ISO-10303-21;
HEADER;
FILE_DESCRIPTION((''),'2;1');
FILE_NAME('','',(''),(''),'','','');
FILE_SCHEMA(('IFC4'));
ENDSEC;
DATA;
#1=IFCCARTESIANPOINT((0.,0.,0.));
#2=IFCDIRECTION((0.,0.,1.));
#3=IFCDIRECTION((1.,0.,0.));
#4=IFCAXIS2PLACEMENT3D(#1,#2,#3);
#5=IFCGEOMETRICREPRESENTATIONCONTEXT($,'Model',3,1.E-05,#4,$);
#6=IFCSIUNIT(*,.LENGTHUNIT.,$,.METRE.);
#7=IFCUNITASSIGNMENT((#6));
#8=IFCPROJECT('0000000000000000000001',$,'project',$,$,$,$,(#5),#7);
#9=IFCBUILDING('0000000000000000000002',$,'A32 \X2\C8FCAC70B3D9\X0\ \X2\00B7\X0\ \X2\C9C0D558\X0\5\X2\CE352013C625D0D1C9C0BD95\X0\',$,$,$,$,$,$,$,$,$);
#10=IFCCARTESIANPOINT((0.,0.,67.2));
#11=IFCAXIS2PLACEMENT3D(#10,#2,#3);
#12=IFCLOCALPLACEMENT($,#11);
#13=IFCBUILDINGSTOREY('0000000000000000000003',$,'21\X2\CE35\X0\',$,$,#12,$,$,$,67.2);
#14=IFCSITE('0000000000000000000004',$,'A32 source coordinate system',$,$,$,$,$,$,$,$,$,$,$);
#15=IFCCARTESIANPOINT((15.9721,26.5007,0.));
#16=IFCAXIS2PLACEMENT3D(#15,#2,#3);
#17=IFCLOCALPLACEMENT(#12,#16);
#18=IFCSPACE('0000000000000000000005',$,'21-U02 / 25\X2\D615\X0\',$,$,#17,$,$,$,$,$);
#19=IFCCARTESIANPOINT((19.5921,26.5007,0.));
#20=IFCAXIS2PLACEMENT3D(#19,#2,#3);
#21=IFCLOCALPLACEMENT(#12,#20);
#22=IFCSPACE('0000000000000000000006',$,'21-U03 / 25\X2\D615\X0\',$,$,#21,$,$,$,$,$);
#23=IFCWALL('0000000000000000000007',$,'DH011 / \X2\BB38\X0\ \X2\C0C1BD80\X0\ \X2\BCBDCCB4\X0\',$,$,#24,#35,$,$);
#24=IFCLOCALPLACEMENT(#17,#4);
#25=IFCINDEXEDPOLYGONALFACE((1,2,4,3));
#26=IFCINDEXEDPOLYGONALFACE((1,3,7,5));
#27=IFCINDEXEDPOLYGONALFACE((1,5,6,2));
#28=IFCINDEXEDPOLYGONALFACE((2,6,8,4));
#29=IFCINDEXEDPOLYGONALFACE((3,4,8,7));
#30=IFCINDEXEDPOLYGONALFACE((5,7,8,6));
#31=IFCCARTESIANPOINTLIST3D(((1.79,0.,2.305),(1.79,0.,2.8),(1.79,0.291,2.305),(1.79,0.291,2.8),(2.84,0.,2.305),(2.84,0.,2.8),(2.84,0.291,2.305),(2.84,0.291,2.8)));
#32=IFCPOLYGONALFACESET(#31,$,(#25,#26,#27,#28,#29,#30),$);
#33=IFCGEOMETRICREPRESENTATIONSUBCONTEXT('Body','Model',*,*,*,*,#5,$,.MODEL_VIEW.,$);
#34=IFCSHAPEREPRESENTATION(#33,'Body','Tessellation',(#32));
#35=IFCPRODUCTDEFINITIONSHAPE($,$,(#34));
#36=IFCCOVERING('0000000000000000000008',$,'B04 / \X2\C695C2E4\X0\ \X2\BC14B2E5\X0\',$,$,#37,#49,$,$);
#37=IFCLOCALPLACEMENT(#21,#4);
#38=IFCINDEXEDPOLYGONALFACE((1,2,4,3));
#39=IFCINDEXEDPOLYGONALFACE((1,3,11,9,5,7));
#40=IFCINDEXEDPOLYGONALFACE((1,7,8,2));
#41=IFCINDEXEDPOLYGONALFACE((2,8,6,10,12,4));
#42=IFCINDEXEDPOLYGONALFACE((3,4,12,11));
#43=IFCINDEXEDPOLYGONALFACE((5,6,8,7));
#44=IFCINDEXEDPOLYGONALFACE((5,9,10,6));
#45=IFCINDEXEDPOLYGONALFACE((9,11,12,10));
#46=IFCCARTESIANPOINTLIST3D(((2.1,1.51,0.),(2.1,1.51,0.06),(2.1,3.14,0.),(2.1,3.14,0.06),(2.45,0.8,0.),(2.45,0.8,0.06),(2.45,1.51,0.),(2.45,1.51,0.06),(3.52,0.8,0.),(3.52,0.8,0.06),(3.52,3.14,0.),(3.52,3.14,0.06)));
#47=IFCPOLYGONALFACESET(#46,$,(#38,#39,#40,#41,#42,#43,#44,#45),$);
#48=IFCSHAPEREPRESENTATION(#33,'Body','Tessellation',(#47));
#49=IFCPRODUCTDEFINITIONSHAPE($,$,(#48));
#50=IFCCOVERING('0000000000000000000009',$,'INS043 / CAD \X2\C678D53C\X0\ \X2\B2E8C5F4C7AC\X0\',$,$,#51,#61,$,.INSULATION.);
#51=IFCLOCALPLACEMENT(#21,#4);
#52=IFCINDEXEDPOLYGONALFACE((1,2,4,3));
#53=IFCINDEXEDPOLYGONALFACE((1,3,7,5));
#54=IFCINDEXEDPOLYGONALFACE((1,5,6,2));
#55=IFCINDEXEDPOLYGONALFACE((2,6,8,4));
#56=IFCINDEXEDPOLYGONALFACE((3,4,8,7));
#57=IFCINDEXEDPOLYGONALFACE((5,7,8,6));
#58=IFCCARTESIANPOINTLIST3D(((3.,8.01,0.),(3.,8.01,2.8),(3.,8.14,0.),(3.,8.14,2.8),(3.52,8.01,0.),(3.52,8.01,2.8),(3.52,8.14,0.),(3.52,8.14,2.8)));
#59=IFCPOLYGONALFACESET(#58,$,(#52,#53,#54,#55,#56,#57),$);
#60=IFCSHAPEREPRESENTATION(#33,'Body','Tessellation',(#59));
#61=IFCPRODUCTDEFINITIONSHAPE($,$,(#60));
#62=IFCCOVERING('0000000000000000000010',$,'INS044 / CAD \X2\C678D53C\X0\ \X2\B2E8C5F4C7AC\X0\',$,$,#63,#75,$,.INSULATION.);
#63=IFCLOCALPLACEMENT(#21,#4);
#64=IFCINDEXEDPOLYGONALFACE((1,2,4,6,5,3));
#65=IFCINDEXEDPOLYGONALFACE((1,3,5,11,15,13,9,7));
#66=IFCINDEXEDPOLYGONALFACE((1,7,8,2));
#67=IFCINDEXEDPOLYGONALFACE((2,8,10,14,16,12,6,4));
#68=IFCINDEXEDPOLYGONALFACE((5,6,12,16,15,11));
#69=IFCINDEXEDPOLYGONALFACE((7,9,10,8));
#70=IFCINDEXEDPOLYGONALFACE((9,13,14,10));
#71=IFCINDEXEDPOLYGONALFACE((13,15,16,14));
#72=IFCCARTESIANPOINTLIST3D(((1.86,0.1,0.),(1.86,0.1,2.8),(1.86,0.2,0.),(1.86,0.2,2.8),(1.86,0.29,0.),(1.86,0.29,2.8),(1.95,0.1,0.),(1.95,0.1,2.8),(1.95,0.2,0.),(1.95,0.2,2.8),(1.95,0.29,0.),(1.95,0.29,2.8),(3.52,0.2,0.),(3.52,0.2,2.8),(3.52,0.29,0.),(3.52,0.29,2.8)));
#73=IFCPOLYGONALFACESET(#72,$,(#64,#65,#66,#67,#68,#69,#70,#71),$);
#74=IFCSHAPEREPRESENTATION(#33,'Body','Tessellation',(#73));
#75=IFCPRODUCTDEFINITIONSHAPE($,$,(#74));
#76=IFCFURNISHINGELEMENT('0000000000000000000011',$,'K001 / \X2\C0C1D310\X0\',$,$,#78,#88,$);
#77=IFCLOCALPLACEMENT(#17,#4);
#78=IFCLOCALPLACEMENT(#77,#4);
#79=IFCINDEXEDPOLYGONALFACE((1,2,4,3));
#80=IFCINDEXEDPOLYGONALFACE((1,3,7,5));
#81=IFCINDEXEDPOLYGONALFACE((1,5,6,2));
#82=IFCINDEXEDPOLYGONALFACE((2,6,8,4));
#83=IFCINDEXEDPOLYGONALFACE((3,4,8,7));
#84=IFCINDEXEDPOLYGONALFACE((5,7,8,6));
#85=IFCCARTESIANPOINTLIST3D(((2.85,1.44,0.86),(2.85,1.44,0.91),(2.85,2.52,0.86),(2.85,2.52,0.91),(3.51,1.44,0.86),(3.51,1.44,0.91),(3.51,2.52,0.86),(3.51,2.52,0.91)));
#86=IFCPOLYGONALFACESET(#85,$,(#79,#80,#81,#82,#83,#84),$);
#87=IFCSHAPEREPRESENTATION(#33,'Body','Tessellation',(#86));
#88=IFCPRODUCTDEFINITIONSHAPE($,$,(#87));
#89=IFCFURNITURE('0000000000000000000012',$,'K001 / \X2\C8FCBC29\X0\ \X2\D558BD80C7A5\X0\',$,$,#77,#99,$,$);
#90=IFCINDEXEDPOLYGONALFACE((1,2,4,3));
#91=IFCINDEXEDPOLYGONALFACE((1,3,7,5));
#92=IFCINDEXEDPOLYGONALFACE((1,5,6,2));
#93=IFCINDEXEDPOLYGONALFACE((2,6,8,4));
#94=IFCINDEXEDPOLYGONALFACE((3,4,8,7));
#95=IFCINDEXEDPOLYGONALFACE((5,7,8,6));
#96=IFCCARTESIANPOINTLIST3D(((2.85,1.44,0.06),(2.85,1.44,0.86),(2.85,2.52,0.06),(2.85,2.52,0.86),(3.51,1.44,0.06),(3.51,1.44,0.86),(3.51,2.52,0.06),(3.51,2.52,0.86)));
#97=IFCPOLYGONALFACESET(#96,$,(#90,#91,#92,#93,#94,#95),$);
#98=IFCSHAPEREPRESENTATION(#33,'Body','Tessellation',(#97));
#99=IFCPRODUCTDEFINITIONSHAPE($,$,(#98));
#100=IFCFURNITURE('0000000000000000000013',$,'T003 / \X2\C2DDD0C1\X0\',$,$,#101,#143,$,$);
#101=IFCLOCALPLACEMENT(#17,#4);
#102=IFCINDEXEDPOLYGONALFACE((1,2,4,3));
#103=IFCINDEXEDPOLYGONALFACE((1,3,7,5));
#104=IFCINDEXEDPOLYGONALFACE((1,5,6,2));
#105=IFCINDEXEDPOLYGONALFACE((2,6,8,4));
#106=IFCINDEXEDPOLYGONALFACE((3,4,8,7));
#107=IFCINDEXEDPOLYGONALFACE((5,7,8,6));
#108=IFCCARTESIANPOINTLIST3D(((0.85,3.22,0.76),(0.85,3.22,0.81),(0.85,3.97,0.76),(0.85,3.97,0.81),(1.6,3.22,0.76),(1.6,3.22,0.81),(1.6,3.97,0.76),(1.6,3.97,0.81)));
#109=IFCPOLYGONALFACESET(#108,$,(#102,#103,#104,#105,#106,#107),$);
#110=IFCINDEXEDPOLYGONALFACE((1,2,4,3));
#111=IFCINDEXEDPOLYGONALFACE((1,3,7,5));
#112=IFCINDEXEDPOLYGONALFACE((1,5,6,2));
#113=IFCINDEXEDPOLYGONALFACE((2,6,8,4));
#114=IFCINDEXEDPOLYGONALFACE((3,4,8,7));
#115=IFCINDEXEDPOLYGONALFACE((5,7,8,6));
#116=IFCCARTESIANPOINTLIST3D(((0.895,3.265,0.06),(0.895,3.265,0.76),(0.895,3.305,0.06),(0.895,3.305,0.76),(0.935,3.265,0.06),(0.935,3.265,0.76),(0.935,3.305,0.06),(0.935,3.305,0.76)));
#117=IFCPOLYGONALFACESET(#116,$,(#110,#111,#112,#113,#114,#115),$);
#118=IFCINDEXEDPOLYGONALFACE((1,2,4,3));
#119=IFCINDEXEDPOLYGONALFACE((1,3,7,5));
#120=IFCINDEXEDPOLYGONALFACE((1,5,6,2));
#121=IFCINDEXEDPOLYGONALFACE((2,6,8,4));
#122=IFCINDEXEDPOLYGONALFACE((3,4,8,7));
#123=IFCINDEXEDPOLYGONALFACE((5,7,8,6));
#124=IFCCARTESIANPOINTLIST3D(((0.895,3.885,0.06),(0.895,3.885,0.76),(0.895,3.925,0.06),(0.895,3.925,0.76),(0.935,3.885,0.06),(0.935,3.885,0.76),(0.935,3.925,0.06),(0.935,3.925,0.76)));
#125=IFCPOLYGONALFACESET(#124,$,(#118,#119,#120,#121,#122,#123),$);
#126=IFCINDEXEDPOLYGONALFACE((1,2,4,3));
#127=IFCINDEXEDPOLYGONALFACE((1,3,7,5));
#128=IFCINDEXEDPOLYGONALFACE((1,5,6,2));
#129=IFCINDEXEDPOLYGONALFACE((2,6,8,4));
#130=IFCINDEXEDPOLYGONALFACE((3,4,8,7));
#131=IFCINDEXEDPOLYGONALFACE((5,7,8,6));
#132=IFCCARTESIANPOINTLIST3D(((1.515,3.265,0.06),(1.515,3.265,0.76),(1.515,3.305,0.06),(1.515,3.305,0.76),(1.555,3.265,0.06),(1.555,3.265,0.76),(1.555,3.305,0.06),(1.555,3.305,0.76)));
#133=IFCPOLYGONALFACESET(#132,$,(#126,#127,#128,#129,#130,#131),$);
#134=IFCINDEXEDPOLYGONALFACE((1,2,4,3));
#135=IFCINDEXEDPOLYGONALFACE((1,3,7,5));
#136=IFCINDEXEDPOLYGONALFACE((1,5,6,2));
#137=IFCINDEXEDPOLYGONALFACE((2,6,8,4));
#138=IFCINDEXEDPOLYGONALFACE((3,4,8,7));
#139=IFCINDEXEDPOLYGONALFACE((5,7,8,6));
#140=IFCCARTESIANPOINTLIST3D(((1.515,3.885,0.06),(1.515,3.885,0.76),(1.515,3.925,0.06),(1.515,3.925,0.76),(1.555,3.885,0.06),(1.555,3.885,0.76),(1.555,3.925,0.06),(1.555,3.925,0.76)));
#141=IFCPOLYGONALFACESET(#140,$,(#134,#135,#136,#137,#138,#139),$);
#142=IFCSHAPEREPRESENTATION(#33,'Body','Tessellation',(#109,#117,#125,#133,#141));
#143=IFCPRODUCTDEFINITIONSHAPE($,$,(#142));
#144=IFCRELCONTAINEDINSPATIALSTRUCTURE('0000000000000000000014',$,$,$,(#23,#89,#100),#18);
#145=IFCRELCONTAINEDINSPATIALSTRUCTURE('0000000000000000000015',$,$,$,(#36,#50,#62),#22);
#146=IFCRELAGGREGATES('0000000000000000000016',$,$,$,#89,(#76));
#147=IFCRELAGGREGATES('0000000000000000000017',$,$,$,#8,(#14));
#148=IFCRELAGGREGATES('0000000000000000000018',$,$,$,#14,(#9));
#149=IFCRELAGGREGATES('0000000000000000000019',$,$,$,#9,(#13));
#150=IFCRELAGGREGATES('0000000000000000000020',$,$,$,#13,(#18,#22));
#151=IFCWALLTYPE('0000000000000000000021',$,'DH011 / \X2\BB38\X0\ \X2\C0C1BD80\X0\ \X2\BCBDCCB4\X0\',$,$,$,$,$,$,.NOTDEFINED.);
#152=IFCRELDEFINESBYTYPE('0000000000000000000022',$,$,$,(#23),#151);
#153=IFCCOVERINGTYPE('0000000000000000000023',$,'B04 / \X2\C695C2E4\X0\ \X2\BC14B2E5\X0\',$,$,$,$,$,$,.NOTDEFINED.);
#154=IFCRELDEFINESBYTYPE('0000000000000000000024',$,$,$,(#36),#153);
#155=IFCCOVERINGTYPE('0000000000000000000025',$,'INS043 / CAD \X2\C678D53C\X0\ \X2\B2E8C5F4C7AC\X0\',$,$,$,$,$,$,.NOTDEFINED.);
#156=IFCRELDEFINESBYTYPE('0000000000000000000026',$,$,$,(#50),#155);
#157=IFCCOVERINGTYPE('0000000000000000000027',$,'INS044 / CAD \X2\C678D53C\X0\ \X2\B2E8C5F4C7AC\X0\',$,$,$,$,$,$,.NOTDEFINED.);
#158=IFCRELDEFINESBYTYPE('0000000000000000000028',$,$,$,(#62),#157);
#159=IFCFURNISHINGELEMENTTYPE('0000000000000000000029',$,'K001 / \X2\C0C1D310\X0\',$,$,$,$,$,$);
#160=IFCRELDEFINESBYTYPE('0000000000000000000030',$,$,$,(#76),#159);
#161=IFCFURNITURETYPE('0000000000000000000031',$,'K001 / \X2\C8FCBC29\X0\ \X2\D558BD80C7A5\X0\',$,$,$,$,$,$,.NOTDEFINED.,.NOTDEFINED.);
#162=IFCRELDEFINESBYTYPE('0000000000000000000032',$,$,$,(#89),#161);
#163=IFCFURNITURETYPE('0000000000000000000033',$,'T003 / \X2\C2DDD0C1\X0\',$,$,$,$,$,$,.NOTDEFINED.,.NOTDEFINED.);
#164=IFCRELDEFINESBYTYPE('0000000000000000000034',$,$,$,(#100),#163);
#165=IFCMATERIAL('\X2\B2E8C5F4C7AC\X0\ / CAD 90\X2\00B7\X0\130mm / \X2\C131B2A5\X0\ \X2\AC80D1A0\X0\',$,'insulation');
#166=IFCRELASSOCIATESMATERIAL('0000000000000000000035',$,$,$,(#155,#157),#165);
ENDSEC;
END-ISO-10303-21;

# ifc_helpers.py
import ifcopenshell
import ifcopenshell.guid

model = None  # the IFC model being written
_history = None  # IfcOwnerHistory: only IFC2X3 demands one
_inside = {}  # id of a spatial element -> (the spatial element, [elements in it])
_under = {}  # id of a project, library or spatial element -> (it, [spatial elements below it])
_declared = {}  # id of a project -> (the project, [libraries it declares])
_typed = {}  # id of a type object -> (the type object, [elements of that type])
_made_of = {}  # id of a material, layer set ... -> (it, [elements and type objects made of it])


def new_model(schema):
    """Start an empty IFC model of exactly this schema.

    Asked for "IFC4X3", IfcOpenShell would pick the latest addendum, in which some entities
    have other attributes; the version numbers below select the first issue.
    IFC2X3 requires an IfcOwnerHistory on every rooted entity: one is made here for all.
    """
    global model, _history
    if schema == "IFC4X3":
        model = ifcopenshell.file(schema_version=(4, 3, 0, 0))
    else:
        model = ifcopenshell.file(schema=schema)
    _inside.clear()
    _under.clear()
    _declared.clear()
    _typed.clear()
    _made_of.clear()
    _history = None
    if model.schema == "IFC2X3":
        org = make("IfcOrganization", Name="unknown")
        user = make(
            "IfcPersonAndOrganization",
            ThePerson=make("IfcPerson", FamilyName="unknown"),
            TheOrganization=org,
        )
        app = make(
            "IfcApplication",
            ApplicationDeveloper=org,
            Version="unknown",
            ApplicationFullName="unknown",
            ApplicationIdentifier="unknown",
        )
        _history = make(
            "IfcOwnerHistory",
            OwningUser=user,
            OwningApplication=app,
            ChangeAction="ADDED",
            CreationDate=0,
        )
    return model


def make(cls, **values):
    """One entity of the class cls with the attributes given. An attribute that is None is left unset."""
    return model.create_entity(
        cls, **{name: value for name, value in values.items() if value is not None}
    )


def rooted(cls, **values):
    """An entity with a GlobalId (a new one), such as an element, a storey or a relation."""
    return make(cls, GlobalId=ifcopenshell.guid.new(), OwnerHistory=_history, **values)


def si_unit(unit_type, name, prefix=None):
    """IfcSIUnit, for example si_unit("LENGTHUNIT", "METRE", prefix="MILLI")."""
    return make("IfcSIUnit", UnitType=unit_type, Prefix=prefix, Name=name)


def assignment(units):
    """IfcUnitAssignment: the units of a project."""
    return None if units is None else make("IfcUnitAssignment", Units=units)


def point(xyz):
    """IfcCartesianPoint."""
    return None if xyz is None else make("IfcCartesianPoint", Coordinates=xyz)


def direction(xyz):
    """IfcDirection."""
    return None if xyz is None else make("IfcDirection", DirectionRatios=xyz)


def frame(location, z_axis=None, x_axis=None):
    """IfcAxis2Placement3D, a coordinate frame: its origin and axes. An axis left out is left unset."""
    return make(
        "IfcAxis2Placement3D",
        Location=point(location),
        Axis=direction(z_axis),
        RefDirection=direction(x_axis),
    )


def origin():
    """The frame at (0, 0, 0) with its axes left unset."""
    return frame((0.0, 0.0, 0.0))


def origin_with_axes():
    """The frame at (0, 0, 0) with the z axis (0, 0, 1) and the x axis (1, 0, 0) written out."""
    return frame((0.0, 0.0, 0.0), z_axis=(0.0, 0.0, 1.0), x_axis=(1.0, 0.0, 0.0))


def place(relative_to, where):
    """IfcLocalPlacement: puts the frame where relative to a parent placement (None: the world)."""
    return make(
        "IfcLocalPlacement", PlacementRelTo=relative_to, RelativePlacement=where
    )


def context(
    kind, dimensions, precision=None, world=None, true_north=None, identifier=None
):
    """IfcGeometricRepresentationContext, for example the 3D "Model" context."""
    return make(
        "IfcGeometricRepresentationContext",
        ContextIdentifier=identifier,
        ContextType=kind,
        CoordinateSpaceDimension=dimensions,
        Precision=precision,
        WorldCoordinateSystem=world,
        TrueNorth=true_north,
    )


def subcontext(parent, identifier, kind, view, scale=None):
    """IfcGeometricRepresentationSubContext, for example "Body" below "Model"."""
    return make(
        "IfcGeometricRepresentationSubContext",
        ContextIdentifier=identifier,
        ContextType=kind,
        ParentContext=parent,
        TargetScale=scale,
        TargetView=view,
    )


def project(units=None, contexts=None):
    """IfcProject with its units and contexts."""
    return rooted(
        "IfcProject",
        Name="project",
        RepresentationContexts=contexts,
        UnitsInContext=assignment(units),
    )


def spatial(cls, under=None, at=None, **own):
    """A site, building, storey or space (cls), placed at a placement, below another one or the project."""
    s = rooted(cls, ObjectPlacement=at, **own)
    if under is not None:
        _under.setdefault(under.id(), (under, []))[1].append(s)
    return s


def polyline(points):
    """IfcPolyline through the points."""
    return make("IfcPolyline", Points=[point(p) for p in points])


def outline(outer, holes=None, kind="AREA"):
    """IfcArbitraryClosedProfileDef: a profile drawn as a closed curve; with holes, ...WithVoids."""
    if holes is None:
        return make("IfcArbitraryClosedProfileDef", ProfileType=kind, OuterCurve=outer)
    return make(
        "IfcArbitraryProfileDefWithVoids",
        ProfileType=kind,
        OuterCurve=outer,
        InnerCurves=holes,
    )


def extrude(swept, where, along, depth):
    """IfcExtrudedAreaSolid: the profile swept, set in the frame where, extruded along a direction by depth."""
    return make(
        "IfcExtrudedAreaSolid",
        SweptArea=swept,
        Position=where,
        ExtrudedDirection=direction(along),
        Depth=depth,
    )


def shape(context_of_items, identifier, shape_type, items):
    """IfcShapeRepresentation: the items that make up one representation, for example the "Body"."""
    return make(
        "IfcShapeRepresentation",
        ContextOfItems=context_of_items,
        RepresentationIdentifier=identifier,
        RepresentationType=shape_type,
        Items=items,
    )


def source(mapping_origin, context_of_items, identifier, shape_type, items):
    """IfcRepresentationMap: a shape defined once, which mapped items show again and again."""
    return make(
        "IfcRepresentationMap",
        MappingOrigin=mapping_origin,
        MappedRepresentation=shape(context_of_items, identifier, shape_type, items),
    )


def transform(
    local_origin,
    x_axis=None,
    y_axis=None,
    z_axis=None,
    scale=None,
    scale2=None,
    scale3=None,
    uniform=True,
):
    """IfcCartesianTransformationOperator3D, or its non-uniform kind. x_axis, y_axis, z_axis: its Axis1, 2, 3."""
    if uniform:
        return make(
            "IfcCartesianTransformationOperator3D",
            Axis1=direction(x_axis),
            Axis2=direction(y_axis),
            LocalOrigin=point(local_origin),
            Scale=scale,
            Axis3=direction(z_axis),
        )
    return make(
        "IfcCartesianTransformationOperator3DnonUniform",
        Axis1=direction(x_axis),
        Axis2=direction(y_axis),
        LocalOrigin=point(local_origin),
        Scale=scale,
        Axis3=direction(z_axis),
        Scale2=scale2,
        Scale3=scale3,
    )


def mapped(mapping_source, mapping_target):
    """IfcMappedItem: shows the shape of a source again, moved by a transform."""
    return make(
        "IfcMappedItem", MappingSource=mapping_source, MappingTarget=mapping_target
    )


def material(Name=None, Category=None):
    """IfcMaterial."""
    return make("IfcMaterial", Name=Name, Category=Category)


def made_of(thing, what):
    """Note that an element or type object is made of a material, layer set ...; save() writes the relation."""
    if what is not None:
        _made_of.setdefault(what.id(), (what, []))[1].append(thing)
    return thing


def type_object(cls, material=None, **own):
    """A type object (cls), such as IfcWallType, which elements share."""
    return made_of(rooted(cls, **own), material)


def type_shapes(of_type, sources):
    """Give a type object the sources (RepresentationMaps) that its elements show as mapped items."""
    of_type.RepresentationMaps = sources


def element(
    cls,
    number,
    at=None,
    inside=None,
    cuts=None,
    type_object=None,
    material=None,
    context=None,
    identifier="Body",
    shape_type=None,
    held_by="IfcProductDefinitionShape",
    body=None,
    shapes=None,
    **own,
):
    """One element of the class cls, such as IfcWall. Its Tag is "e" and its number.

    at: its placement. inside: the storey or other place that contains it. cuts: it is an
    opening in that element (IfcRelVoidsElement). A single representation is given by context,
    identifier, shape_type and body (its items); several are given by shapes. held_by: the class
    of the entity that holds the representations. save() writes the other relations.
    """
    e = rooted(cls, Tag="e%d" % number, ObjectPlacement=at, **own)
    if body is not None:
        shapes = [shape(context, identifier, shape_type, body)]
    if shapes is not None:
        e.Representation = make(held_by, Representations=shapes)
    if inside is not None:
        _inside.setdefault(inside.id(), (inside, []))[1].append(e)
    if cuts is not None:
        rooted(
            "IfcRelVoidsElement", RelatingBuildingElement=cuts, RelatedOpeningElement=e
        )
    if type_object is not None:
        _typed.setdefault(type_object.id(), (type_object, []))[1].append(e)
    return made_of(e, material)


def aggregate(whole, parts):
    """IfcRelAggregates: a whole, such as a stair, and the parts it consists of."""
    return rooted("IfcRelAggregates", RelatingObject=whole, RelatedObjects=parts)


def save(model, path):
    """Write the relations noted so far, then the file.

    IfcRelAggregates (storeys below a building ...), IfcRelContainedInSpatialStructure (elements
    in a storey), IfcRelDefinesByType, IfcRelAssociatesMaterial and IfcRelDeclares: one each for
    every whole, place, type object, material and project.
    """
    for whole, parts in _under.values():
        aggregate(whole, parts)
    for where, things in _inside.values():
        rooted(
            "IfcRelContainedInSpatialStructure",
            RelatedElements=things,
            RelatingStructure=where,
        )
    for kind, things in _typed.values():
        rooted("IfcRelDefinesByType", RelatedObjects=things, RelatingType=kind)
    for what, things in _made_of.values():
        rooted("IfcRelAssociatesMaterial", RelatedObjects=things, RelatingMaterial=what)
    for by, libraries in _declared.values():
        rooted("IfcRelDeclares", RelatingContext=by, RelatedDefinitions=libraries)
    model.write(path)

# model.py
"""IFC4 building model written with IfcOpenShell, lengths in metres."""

from ifc_helpers import new_model, si_unit, frame, origin, origin_with_axes, place, context, subcontext, project, spatial, polyline, outline, extrude, source, transform, mapped, material, type_object, type_shapes, element, aggregate, save


model = new_model("IFC4")

# Units and contexts
model_context = context("Model", 3, precision=1e-05, world=origin_with_axes())
body_context = subcontext(model_context, "Body", "Model", "MODEL_VIEW")
ifc_project = project(units=[si_unit("LENGTHUNIT", "METRE")], contexts=[model_context])

# Site, building, storey, space
site = spatial("IfcSite", under=ifc_project, Name="A32 source coordinate system")
building = spatial("IfcBuilding", under=site, Name="A32 주거동 · 지하5층–옥탑지붕")
storey_placement = place(None, frame((0.0, 0.0, 67.2), z_axis=(0.0, 0.0, 1.0), x_axis=(1.0, 0.0, 0.0)))
storey = spatial("IfcBuildingStorey", under=building, at=storey_placement, Name="21층", Elevation=67.2)
space_1_placement = place(storey_placement, frame((15.9721, 26.5007, 0.0), z_axis=(0.0, 0.0, 1.0), x_axis=(1.0, 0.0, 0.0)))
space_1 = spatial("IfcSpace", under=storey, at=space_1_placement, Name="21-U02 / 25형")

# Wall
wall_type_1 = type_object("IfcWallType", Name="DH011 / 문 상부 벽체", PredefinedType="NOTDEFINED")
shared_shape_1 = source(origin(), body_context, "Body", "SweptSolid", [
    extrude(outline(polyline([(2.84, 0.0), (1.79, 0.0), (1.79, 0.291), (2.84, 0.291), (2.84, 0.0)])), frame((0.0, 0.0, 2.305)), (0.0, 0.0, 1.0), 0.495),
])
type_shapes(wall_type_1, [shared_shape_1])
wall_1_placement = place(space_1_placement, origin_with_axes())
element("IfcWall", 1, at=wall_1_placement, inside=space_1, type_object=wall_type_1, Name="DH011 / 문 상부 벽체", context=body_context, shape_type="MappedRepresentation", body=[
    mapped(shared_shape_1, transform((0.0, 0.0, 0.0), scale=1.0)),
])

# Shared definitions
space_2_placement = place(storey_placement, frame((19.5921, 26.5007, 0.0), z_axis=(0.0, 0.0, 1.0), x_axis=(1.0, 0.0, 0.0)))
space_2 = spatial("IfcSpace", under=storey, at=space_2_placement, Name="21-U03 / 25형")

# Coverings
covering_type_1 = type_object("IfcCoveringType", Name="B04 / 욕실 바닥", PredefinedType="NOTDEFINED")
shared_shape_2 = source(origin(), body_context, "Body", "SweptSolid", [
    extrude(outline(polyline([(2.1, 1.51), (2.1, 3.14), (3.52, 3.14), (3.52, 0.8), (2.45, 0.8), (2.45, 1.51), (2.1, 1.51)])), origin(), (0.0, 0.0, 1.0), 0.06),
])
type_shapes(covering_type_1, [shared_shape_2])
covering_1_placement = place(space_2_placement, origin_with_axes())
element("IfcCovering", 2, at=covering_1_placement, inside=space_2, type_object=covering_type_1, Name="B04 / 욕실 바닥", context=body_context, shape_type="MappedRepresentation", body=[
    mapped(shared_shape_2, transform((0.0, 0.0, 0.0), scale=1.0)),
])
ifc_material = material(Name="단열재 / CAD 90·130mm / 성능 검토", Category="insulation")
covering_type_2 = type_object("IfcCoveringType", Name="INS043 / CAD 외피 단열재", PredefinedType="NOTDEFINED", material=ifc_material)
shared_shape_3 = source(origin(), body_context, "Body", "SweptSolid", [
    extrude(outline(polyline([(3.52, 8.14), (3.52, 8.01), (3.0, 8.01), (3.0, 8.14), (3.52, 8.14)])), origin(), (0.0, 0.0, 1.0), 2.8),
])
type_shapes(covering_type_2, [shared_shape_3])
covering_2_placement = place(space_2_placement, origin_with_axes())
element("IfcCovering", 3, at=covering_2_placement, inside=space_2, type_object=covering_type_2, Name="INS043 / CAD 외피 단열재", PredefinedType="INSULATION", context=body_context, shape_type="MappedRepresentation", body=[
    mapped(shared_shape_3, transform((0.0, 0.0, 0.0), scale=1.0)),
])
covering_type_3 = type_object("IfcCoveringType", Name="INS044 / CAD 외피 단열재", PredefinedType="NOTDEFINED", material=ifc_material)
shared_shape_4 = source(origin(), body_context, "Body", "SweptSolid", [
    extrude(outline(polyline([(1.86, 0.2), (1.86, 0.29), (1.95, 0.29), (3.52, 0.29), (3.52, 0.2), (1.95, 0.2), (1.95, 0.1), (1.86, 0.1), (1.86, 0.2)])), origin(), (0.0, 0.0, 1.0), 2.8),
])
type_shapes(covering_type_3, [shared_shape_4])
covering_3_placement = place(space_2_placement, origin_with_axes())
element("IfcCovering", 4, at=covering_3_placement, inside=space_2, type_object=covering_type_3, Name="INS044 / CAD 외피 단열재", PredefinedType="INSULATION", context=body_context, shape_type="MappedRepresentation", body=[
    mapped(shared_shape_4, transform((0.0, 0.0, 0.0), scale=1.0)),
])

# Furnishing element
furnishing_element_type_1 = type_object("IfcFurnishingElementType", Name="K001 / 상판")
shared_shape_5 = source(origin(), body_context, "Body", "SweptSolid", [
    extrude(outline(polyline([(2.85, 2.52), (3.51, 2.52), (3.51, 1.44), (2.85, 1.44), (2.85, 2.52)])), frame((0.0, 0.0, 0.86)), (0.0, 0.0, 1.0), 0.05),
])
type_shapes(furnishing_element_type_1, [shared_shape_5])
furniture_1_placement = place(space_1_placement, origin_with_axes())
furnishing_1_placement = place(furniture_1_placement, origin_with_axes())
furnishing_1 = element("IfcFurnishingElement", 5, at=furnishing_1_placement, type_object=furnishing_element_type_1, Name="K001 / 상판", context=body_context, shape_type="MappedRepresentation", body=[
    mapped(shared_shape_5, transform((0.0, 0.0, 0.0), scale=1.0)),
])

# Furniture
furniture_type_1 = type_object("IfcFurnitureType", Name="K001 / 주방 하부장", AssemblyPlace="NOTDEFINED", PredefinedType="NOTDEFINED")
shared_shape_6 = source(origin(), body_context, "Body", "SweptSolid", [
    extrude(outline(polyline([(2.85, 1.44), (2.85, 2.52), (3.51, 2.52), (3.51, 1.44), (2.85, 1.44)])), frame((0.0, 0.0, 0.06)), (0.0, 0.0, 1.0), 0.8),
])
type_shapes(furniture_type_1, [shared_shape_6])
furniture_1 = element("IfcFurniture", 6, at=furniture_1_placement, inside=space_1, type_object=furniture_type_1, Name="K001 / 주방 하부장", context=body_context, shape_type="MappedRepresentation", body=[
    mapped(shared_shape_6, transform((0.0, 0.0, 0.0), scale=1.0)),
])
aggregate(furniture_1, [furnishing_1])
furniture_type_2 = type_object("IfcFurnitureType", Name="T003 / 식탁", AssemblyPlace="NOTDEFINED", PredefinedType="NOTDEFINED")
shared_shape_7 = source(origin(), body_context, "Body", "SweptSolid", [
    extrude(outline(polyline([(1.6, 3.97), (1.6, 3.22), (0.85, 3.22), (0.85, 3.97), (1.6, 3.97)])), frame((0.0, 0.0, 0.76)), (0.0, 0.0, 1.0), 0.05),
    extrude(outline(polyline([(0.895, 3.265), (0.895, 3.305), (0.935, 3.305), (0.935, 3.265), (0.895, 3.265)])), frame((0.0, 0.0, 0.06)), (0.0, 0.0, 1.0), 0.7),
    extrude(outline(polyline([(0.895, 3.885), (0.895, 3.925), (0.935, 3.925), (0.935, 3.885), (0.895, 3.885)])), frame((0.0, 0.0, 0.06)), (0.0, 0.0, 1.0), 0.7),
    extrude(outline(polyline([(1.515, 3.265), (1.515, 3.305), (1.555, 3.305), (1.555, 3.265), (1.515, 3.265)])), frame((0.0, 0.0, 0.06)), (0.0, 0.0, 1.0), 0.7),
    extrude(outline(polyline([(1.515, 3.885), (1.515, 3.925), (1.555, 3.925), (1.555, 3.885), (1.515, 3.885)])), frame((0.0, 0.0, 0.06)), (0.0, 0.0, 1.0), 0.7),
])
type_shapes(furniture_type_2, [shared_shape_7])
furniture_2_placement = place(space_1_placement, origin_with_axes())
element("IfcFurniture", 7, at=furniture_2_placement, inside=space_1, type_object=furniture_type_2, Name="T003 / 식탁", context=body_context, shape_type="MappedRepresentation", body=[
    mapped(shared_shape_7, transform((0.0, 0.0, 0.0), scale=1.0)),
])

save(model, "model.ifc")
